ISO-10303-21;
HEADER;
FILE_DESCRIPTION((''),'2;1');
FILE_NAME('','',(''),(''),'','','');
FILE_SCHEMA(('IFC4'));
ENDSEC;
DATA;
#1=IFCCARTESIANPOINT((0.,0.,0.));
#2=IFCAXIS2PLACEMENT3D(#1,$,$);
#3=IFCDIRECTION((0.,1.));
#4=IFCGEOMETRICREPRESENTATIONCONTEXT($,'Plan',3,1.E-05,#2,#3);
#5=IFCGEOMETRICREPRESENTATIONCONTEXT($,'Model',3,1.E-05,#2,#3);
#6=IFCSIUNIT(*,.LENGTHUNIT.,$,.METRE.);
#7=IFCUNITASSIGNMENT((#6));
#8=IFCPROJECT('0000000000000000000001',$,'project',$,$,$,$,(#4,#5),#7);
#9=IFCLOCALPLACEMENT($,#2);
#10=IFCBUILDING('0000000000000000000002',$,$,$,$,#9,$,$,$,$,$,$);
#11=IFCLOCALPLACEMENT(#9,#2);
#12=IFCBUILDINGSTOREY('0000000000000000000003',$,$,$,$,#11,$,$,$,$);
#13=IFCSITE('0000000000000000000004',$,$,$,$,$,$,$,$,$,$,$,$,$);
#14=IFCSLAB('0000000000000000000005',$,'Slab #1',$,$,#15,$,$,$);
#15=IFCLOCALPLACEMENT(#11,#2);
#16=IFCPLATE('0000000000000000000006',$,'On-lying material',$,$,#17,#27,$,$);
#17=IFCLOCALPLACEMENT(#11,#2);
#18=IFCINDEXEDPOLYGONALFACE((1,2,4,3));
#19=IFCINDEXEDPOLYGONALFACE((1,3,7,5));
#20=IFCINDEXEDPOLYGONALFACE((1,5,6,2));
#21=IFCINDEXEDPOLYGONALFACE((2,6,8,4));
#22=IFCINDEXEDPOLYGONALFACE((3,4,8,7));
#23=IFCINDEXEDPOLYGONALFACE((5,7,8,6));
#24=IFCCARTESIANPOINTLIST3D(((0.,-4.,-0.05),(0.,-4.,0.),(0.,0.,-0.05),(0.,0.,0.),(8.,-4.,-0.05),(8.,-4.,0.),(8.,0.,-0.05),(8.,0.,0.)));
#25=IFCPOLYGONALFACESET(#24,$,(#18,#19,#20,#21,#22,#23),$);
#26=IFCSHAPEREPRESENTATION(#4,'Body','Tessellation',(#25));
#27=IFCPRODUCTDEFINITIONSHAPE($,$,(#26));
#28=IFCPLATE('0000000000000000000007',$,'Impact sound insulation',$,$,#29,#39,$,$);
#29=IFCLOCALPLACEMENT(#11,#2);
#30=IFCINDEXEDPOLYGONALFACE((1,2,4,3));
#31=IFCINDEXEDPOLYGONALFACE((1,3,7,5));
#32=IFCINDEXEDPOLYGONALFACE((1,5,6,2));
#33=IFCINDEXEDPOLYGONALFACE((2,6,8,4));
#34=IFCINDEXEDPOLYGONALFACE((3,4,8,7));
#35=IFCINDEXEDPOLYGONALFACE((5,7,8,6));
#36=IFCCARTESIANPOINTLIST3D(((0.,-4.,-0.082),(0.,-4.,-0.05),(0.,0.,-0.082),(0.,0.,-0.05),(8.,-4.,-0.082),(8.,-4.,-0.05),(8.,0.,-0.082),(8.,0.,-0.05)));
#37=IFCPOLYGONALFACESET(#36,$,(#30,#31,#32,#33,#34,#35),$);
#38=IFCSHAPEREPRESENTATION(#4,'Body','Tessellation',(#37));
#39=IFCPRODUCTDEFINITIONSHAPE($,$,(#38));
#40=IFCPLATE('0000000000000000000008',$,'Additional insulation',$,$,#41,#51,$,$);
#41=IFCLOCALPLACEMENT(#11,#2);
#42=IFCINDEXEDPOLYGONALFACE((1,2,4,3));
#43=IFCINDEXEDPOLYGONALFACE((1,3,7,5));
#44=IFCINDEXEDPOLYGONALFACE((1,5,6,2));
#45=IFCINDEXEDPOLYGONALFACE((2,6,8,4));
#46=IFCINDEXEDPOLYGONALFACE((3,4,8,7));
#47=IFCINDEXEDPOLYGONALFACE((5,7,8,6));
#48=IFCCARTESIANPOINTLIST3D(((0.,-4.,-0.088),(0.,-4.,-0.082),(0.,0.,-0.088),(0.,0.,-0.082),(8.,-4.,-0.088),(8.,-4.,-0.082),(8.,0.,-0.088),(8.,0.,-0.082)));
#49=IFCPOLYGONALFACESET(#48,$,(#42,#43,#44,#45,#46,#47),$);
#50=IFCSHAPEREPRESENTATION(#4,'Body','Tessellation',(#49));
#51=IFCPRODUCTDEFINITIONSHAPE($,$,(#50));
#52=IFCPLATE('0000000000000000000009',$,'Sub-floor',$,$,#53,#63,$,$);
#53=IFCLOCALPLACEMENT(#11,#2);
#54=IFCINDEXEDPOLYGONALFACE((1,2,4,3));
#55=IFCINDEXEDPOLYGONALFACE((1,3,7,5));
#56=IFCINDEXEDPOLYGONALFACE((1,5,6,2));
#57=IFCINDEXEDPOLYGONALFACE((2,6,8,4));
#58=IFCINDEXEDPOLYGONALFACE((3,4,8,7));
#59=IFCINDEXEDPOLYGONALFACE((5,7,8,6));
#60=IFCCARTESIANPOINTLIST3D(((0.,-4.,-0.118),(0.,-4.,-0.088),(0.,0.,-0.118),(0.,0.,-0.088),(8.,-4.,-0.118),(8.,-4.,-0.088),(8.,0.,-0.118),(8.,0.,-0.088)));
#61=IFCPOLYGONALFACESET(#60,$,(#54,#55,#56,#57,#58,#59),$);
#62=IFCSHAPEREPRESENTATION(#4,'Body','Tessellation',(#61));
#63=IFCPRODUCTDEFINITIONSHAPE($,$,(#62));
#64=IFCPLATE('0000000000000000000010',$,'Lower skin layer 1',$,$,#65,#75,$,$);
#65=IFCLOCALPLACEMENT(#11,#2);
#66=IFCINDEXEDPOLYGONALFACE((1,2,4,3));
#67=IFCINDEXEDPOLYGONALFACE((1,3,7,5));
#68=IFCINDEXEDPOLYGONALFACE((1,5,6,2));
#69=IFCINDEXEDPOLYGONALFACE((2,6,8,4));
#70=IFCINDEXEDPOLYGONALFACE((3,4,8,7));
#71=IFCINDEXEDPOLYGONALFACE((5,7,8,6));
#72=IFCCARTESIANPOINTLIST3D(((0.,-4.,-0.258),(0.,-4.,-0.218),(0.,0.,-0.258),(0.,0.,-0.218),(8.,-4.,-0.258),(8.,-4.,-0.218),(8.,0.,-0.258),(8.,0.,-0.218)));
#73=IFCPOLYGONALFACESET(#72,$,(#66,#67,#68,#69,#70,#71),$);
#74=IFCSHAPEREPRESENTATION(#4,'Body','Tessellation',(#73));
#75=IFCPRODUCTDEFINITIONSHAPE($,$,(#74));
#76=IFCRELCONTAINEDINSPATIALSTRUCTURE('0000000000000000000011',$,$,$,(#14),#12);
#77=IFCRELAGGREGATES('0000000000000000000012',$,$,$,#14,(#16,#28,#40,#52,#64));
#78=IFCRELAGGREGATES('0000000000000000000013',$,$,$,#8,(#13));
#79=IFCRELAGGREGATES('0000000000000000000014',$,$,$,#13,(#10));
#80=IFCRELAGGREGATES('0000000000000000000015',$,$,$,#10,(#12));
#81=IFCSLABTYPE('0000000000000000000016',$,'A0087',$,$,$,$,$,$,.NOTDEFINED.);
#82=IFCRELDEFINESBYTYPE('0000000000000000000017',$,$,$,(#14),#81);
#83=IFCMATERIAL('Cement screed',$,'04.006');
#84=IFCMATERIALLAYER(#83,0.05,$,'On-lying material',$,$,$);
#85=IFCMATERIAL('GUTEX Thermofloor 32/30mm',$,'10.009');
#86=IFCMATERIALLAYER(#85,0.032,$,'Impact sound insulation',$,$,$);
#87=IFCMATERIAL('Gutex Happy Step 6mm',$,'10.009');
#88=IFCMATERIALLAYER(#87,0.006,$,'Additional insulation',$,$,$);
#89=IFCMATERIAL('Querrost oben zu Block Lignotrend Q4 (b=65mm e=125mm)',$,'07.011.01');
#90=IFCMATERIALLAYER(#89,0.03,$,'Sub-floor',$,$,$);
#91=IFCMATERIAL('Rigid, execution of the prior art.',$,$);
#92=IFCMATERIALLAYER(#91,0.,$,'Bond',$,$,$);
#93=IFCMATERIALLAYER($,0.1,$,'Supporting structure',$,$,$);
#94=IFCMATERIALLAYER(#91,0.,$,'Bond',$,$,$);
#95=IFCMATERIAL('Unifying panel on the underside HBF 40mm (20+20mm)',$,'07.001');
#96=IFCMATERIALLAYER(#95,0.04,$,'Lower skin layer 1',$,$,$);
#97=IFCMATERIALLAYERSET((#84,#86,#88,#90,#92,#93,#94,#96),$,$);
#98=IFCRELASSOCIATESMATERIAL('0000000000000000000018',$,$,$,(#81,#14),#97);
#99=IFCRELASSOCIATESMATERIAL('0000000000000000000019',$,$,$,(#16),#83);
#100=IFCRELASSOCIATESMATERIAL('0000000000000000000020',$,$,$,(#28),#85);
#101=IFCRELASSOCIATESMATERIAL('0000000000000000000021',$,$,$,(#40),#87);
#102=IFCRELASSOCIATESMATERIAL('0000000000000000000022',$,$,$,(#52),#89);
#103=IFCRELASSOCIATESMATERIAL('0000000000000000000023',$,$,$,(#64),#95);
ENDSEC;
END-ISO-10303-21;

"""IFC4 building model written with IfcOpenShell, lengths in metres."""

from ifc_helpers import new_model, si_unit, direction, frame, frame_2d, origin, origin_with_axes, place, context, project, spatial, rectangle, extrude, material, layer, layer_set, type_object, element, aggregate, save


model = new_model("IFC4")

# Units and contexts
plan_context = context("Plan", 3, precision=1e-05, world=origin(), true_north=direction((0.0, 1.0)))
model_context = context("Model", 3, precision=1e-05, world=origin(), true_north=direction((0.0, 1.0)))
ifc_project = project(units=[si_unit("LENGTHUNIT", "METRE")], contexts=[plan_context, model_context])

# Site, building, storey
site = spatial("IfcSite", under=ifc_project)
building_placement = place(None, origin())
building = spatial("IfcBuilding", under=site, at=building_placement)
storey_placement = place(building_placement, origin())
storey = spatial("IfcBuildingStorey", under=building, at=storey_placement)

# Slab, plates
ifc_material_1 = material(Name="Cement screed", Category="04.006")
ifc_layer_1 = layer(ifc_material_1, 0.05, Name="On-lying material")
ifc_material_2 = material(Name="GUTEX Thermofloor 32/30mm", Category="10.009")
ifc_layer_2 = layer(ifc_material_2, 0.032, Name="Impact sound insulation")
ifc_material_3 = material(Name="Gutex Happy Step 6mm", Category="10.009")
ifc_layer_3 = layer(ifc_material_3, 0.006, Name="Additional insulation")
ifc_material_4 = material(Name="Querrost oben zu Block Lignotrend Q4 (b=65mm e=125mm)", Category="07.011.01")
ifc_layer_4 = layer(ifc_material_4, 0.03, Name="Sub-floor")
ifc_material_5 = material(Name="Rigid, execution of the prior art.")
ifc_layer_5 = layer(ifc_material_5, 0.0, Name="Bond")
ifc_layer_6 = layer(None, 0.1, Name="Supporting structure")
ifc_layer_7 = layer(ifc_material_5, 0.0, Name="Bond")
ifc_material_6 = material(Name="Unifying panel on the underside HBF 40mm (20+20mm)", Category="07.001")
ifc_layer_8 = layer(ifc_material_6, 0.04, Name="Lower skin layer 1")
ifc_layer_set = layer_set([ifc_layer_1, ifc_layer_2, ifc_layer_3, ifc_layer_4, ifc_layer_5, ifc_layer_6, ifc_layer_7, ifc_layer_8])
slab_type = type_object("IfcSlabType", Name="A0087", PredefinedType="NOTDEFINED", material=ifc_layer_set)
slab_placement = place(None, frame((0.0, 0.0, 0.0), z_axis=(0.0, 0.0, -1.0), x_axis=(1.0, 0.0, 0.0)))
slab = element("IfcSlab", 1, at=slab_placement, inside=storey, type_object=slab_type, material=ifc_layer_set, Name="Slab #1")
plate_1_placement = place(slab_placement, origin())
plate_1 = element("IfcPlate", 2, at=plate_1_placement, material=ifc_material_1, Name="On-lying material", context=plan_context, shape_type="SweptSolid", body=[
    extrude(rectangle(XDim=8.0, YDim=4.0, at=frame_2d((4.0, 2.0), x_axis=(1.0, 0.0))), origin_with_axes(), (0.0, 0.0, 1.0), 0.05),
])
plate_2_placement = place(slab_placement, origin())
plate_2 = element("IfcPlate", 3, at=plate_2_placement, material=ifc_material_2, Name="Impact sound insulation", context=plan_context, shape_type="SweptSolid", body=[
    extrude(rectangle(XDim=8.0, YDim=4.0, at=frame_2d((4.0, 2.0), x_axis=(1.0, 0.0))), frame((0.0, 0.0, 0.05), z_axis=(0.0, 0.0, 1.0), x_axis=(1.0, 0.0, 0.0)), (0.0, 0.0, 1.0), 0.032),
])
plate_3_placement = place(slab_placement, origin())
plate_3 = element("IfcPlate", 4, at=plate_3_placement, material=ifc_material_3, Name="Additional insulation", context=plan_context, shape_type="SweptSolid", body=[
    extrude(rectangle(XDim=8.0, YDim=4.0, at=frame_2d((4.0, 2.0), x_axis=(1.0, 0.0))), frame((0.0, 0.0, 0.082), z_axis=(0.0, 0.0, 1.0), x_axis=(1.0, 0.0, 0.0)), (0.0, 0.0, 1.0), 0.006),
])
plate_4_placement = place(slab_placement, origin())
plate_4 = element("IfcPlate", 5, at=plate_4_placement, material=ifc_material_4, Name="Sub-floor", context=plan_context, shape_type="SweptSolid", body=[
    extrude(rectangle(XDim=8.0, YDim=4.0, at=frame_2d((4.0, 2.0), x_axis=(1.0, 0.0))), frame((0.0, 0.0, 0.088), z_axis=(0.0, 0.0, 1.0), x_axis=(1.0, 0.0, 0.0)), (0.0, 0.0, 1.0), 0.03),
])
plate_5_placement = place(slab_placement, origin())
plate_5 = element("IfcPlate", 6, at=plate_5_placement, material=ifc_material_6, Name="Lower skin layer 1", context=plan_context, shape_type="SweptSolid", body=[
    extrude(rectangle(XDim=8.0, YDim=4.0, at=frame_2d((4.0, 2.0), x_axis=(1.0, 0.0))), frame((0.0, 0.0, 0.218), z_axis=(0.0, 0.0, 1.0), x_axis=(1.0, 0.0, 0.0)), (0.0, 0.0, 1.0), 0.04),
])
aggregate(slab, [plate_1, plate_2, plate_3, plate_4, plate_5])

save(model, "model.ifc")
